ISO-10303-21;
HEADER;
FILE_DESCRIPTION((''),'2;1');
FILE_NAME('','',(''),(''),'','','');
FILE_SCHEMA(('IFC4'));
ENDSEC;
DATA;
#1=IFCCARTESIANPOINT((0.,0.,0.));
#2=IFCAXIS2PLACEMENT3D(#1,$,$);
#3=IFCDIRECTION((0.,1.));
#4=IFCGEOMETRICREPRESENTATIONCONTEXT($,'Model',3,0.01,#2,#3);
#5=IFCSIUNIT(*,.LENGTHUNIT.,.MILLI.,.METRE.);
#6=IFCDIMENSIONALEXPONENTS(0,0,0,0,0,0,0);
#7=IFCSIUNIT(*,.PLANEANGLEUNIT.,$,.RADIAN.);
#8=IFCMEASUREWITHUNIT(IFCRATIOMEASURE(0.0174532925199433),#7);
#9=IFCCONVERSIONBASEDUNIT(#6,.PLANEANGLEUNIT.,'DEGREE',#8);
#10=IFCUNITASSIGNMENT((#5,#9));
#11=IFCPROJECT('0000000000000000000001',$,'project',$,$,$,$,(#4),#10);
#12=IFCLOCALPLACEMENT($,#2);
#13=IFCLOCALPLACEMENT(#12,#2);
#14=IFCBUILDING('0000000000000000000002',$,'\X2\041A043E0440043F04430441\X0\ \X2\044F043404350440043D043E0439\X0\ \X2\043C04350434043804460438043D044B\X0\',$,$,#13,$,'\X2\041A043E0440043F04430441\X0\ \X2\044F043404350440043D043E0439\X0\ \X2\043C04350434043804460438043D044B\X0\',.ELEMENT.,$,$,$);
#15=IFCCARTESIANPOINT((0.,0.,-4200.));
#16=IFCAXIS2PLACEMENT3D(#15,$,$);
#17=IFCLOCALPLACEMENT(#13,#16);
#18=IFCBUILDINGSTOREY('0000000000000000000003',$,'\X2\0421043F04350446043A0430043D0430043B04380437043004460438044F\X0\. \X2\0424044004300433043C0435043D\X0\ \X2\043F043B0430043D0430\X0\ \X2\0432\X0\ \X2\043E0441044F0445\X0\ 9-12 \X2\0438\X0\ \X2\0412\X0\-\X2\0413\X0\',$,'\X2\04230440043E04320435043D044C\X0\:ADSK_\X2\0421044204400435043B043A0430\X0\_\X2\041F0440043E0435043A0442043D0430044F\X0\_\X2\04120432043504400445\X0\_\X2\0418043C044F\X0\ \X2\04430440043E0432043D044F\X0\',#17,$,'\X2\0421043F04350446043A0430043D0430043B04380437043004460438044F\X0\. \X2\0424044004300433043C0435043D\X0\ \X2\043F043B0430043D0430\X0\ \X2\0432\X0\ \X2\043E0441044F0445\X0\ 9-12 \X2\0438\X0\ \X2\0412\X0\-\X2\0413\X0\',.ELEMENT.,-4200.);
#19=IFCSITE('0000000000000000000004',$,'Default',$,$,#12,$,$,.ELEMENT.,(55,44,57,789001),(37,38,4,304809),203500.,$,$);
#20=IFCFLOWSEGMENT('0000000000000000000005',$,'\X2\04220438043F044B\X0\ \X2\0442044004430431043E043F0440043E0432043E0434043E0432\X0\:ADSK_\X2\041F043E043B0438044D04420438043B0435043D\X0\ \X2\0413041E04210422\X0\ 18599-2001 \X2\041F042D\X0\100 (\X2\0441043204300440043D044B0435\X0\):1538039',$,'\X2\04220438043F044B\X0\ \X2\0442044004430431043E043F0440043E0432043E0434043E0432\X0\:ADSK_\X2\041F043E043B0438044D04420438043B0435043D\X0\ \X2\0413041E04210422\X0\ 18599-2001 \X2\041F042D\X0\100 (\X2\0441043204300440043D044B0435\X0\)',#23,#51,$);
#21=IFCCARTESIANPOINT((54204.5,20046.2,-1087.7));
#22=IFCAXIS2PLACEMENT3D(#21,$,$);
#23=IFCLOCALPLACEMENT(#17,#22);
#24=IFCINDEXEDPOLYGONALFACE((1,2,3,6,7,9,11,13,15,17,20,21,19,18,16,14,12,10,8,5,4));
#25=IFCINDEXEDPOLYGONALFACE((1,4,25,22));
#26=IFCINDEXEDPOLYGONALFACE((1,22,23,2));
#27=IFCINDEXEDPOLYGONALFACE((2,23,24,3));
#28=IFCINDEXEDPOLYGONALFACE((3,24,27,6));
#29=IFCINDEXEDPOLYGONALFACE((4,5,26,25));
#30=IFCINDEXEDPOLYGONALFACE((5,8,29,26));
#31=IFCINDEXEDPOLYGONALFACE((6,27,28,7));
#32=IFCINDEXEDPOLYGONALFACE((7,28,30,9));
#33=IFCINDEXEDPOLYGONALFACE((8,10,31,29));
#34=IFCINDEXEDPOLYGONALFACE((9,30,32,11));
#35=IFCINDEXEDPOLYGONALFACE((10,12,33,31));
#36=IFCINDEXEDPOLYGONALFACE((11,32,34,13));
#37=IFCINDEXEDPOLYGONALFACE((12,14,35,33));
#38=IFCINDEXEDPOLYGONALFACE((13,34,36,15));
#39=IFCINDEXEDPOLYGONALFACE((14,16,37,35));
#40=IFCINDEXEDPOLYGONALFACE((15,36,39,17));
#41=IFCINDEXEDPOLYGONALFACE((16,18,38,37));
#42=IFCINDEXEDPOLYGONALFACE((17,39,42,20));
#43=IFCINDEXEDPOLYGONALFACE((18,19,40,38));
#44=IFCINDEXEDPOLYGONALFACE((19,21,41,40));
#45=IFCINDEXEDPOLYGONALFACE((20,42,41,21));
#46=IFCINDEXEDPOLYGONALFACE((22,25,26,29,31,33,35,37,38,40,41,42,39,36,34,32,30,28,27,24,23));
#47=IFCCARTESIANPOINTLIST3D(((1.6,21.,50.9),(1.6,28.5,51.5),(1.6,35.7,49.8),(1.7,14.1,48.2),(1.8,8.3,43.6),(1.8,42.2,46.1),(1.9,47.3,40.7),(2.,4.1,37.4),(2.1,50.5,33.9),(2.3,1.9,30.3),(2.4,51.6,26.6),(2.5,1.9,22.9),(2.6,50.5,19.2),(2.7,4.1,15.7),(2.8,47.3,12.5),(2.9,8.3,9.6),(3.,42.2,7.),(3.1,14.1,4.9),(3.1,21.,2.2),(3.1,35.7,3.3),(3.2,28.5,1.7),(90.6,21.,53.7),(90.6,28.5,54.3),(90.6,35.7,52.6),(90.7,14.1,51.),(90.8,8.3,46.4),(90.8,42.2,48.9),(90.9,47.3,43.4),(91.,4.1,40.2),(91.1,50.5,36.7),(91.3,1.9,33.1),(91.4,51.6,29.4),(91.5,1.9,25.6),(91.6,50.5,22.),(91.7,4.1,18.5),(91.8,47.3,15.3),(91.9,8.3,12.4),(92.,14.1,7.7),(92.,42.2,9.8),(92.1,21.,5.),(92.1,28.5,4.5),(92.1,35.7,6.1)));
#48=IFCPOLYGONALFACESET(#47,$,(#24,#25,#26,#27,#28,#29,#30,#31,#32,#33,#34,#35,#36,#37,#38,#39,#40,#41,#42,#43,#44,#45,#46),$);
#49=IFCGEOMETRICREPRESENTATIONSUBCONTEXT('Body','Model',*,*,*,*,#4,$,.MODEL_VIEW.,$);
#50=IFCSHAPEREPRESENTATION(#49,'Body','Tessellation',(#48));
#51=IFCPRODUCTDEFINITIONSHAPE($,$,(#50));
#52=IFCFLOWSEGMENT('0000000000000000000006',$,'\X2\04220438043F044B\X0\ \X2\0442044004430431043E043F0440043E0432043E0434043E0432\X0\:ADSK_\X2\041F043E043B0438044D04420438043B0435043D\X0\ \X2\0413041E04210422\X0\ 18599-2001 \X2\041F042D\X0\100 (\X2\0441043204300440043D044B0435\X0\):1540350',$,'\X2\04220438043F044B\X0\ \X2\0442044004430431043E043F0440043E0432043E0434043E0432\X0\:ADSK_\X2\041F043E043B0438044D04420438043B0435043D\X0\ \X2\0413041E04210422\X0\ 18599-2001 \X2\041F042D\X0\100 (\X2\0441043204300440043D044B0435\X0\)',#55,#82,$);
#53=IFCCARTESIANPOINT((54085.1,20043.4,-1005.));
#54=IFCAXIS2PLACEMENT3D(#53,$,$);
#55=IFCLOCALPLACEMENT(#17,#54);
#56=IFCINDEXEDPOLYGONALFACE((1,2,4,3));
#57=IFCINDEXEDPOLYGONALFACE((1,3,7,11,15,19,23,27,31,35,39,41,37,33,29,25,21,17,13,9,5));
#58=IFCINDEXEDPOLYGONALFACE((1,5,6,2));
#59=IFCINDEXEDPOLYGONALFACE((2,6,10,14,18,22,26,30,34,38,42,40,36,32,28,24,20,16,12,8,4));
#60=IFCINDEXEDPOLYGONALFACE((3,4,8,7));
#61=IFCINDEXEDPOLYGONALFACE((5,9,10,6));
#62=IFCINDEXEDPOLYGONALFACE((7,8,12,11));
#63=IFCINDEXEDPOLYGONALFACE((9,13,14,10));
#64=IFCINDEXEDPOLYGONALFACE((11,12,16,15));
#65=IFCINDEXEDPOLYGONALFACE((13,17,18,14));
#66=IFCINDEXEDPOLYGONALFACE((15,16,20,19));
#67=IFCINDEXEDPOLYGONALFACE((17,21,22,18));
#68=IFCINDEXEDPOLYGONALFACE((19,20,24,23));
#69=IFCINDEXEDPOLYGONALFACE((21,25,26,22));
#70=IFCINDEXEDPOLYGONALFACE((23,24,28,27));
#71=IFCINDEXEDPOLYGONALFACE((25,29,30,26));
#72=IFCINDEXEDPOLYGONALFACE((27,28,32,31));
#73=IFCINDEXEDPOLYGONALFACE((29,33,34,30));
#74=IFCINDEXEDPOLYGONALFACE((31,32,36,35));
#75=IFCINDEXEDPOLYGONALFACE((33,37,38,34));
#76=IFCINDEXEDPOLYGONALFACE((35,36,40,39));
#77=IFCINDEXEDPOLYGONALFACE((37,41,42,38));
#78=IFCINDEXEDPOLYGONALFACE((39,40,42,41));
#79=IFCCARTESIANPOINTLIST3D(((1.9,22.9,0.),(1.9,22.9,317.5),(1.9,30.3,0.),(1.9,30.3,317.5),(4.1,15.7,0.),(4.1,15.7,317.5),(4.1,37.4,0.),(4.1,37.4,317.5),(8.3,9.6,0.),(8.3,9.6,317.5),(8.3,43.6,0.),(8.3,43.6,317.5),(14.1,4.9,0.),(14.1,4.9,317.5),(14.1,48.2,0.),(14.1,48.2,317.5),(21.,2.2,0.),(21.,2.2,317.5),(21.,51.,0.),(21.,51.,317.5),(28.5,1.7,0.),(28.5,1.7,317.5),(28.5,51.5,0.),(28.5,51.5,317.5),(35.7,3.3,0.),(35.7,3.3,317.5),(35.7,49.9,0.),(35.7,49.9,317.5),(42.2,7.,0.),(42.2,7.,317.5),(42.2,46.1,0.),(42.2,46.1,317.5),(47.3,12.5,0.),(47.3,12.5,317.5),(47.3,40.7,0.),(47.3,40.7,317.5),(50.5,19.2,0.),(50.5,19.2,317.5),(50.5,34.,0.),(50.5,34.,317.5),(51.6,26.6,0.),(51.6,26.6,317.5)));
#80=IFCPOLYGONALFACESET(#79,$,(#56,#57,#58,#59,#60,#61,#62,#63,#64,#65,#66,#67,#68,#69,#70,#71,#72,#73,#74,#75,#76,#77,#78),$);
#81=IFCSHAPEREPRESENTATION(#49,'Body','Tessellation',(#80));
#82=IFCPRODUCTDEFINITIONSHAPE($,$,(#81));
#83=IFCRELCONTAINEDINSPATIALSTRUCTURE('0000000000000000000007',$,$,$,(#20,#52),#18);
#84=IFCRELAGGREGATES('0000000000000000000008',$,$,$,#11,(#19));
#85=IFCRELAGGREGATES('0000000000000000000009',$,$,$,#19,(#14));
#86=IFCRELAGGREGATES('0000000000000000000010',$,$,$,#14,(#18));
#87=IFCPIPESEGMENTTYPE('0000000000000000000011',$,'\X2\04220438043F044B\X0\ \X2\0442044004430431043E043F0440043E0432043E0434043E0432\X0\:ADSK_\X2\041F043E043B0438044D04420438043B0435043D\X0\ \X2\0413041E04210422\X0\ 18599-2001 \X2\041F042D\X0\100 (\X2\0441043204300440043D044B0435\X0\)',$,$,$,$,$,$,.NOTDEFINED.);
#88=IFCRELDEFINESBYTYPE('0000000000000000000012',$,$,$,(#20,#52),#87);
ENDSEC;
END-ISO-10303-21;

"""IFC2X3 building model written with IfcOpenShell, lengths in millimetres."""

from ifc_helpers import new_model, entity, si_unit, converted_unit, direction, frame, frame_2d, origin, origin_2d_with_axis, place, context, subcontext, project, spatial, circle, extrude, type_object, element, save


model = new_model("IFC2X3")

# Units and contexts
model_context = context("Model", 3, precision=0.01, world=origin(), true_north=direction((0.0, 1.0)))
body_context = subcontext(model_context, "Body", "Model", "MODEL_VIEW")
ifc_project = project(units=[si_unit("LENGTHUNIT", "METRE", prefix="MILLI"), converted_unit("PLANEANGLEUNIT", "DEGREE", entity("IfcRatioMeasure", 0.0174532925199433), si_unit("PLANEANGLEUNIT", "RADIAN"), dimensions=[0, 0, 0, 0, 0, 0, 0])], contexts=[model_context])

# Site, building, storey
site_placement = place(None, frame((0.0, 0.0, 0.0)))
site = spatial("IfcSite", under=ifc_project, at=site_placement, Name="Default", CompositionType="ELEMENT", RefLatitude=(55, 44, 57, 789001), RefLongitude=(37, 38, 4, 304809), RefElevation=203500.0)
building_placement = place(site_placement, origin())
building = spatial("IfcBuilding", under=site, at=building_placement, Name="Корпус ядерной медицины", LongName="Корпус ядерной медицины", CompositionType="ELEMENT")
storey_placement = place(building_placement, frame((0.0, 0.0, -4200.0)))
storey = spatial("IfcBuildingStorey", under=building, at=storey_placement, Name="Спецканализация. Фрагмен плана в осях 9-12 и В-Г", ObjectType="Уровень:ADSK_Стрелка_Проектная_Вверх_Имя уровня", LongName="Спецканализация. Фрагмен плана в осях 9-12 и В-Г", CompositionType="ELEMENT", Elevation=-4200.0)

# Flow segments
pipe_segment_type = type_object("IfcPipeSegmentType", Name="Типы трубопроводов:ADSK_Полиэтилен ГОСТ 18599-2001 ПЭ100 (сварные)", PredefinedType="NOTDEFINED")
flow_segment_1_placement = place(storey_placement, frame((54204.5, 20046.2, -1087.7)))
element("IfcFlowSegment", 1, at=flow_segment_1_placement, inside=storey, type_object=pipe_segment_type, Name="Типы трубопроводов:ADSK_Полиэтилен ГОСТ 18599-2001 ПЭ100 (сварные):1538039", ObjectType="Типы трубопроводов:ADSK_Полиэтилен ГОСТ 18599-2001 ПЭ100 (сварные)", context=body_context, shape_type="SweptSolid", body=[
    extrude(circle(Radius=25.0, at=origin_2d_with_axis()), frame((2.4, 26.6, 26.6), z_axis=(0.99951, 0.0, 0.031299), x_axis=(0.0, 1.0, 0.0)), (0.0, 0.0, 1.0), 89.0),
])
flow_segment_2_placement = place(storey_placement, frame((54085.1, 20043.4, -1005.0)))
element("IfcFlowSegment", 2, at=flow_segment_2_placement, inside=storey, type_object=pipe_segment_type, Name="Типы трубопроводов:ADSK_Полиэтилен ГОСТ 18599-2001 ПЭ100 (сварные):1540350", ObjectType="Типы трубопроводов:ADSK_Полиэтилен ГОСТ 18599-2001 ПЭ100 (сварные)", context=body_context, shape_type="SweptSolid", body=[
    extrude(circle(Radius=25.0, at=frame_2d((0.0, 0.0), x_axis=(1.0, 0.0))), frame((26.6, 26.6, 0.0)), (0.0, 0.0, 1.0), 317.5),
])

save(model, "model.ifc")
